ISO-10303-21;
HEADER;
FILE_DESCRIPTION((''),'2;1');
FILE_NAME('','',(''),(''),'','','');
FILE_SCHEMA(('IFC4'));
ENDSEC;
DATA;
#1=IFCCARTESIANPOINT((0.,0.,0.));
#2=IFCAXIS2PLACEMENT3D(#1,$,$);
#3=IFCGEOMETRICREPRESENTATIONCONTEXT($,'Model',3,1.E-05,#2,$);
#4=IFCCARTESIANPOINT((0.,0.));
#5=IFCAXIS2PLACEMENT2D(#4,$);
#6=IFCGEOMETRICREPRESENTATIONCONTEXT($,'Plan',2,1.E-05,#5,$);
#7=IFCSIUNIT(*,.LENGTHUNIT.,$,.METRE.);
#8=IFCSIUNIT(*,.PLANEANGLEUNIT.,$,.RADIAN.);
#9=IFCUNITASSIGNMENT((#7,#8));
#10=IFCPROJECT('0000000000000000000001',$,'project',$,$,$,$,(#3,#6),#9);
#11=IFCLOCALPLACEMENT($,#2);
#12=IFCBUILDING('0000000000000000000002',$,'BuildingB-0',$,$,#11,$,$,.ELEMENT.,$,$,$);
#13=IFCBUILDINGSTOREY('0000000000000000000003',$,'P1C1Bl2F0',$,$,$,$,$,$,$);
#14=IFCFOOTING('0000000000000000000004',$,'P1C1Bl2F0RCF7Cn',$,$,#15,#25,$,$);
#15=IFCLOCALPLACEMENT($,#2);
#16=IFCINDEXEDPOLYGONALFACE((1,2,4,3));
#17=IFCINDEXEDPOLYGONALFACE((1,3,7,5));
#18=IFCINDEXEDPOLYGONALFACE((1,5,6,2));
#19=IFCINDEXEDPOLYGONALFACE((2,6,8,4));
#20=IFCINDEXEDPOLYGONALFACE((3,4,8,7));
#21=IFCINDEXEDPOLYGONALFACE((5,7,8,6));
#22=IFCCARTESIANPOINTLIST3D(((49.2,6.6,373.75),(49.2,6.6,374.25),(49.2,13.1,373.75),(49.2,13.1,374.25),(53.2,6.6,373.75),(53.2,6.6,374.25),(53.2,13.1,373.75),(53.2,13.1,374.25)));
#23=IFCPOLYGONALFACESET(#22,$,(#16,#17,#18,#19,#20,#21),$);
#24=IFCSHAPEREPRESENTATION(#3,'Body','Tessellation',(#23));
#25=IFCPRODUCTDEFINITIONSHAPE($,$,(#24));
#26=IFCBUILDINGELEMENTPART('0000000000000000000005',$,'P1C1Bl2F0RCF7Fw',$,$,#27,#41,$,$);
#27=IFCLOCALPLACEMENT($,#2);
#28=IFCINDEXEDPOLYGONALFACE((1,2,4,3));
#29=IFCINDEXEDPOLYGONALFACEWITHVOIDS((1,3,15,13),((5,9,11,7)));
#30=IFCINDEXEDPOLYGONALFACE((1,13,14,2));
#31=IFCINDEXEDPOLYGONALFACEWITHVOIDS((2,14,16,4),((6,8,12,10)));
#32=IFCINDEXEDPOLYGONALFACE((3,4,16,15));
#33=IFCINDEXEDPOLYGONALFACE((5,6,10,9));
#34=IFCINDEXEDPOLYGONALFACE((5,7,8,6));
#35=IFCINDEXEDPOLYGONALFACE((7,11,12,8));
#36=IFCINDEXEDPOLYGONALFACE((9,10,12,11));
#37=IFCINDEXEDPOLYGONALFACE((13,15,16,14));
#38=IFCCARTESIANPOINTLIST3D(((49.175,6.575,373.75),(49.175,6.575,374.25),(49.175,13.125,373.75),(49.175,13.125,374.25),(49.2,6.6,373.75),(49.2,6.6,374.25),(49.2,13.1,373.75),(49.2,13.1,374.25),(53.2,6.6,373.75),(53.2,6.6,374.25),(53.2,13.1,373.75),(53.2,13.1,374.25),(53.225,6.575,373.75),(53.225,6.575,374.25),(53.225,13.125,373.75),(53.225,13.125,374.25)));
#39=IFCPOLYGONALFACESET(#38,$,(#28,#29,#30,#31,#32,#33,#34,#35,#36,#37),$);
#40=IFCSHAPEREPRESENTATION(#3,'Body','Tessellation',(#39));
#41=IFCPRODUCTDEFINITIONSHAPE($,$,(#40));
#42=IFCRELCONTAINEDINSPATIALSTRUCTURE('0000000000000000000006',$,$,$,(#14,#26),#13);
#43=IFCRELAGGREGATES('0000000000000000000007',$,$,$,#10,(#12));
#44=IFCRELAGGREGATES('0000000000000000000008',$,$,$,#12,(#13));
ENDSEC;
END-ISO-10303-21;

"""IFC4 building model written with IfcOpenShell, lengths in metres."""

from ifc_helpers import new_model, si_unit, origin, origin_2d, place, context, project, spatial, polyline, outline, extrude, element, save


model = new_model("IFC4")

# Units and contexts
model_context = context("Model", 3, precision=1e-05, world=origin())
plan_context = context("Plan", 2, precision=1e-05, world=origin_2d())
ifc_project = project(units=[si_unit("LENGTHUNIT", "METRE"), si_unit("PLANEANGLEUNIT", "RADIAN")], contexts=[model_context, plan_context])

# Building, storey
building_placement = place(None, origin())
building = spatial("IfcBuilding", under=ifc_project, at=building_placement, Name="BuildingB-0", CompositionType="ELEMENT")
storey = spatial("IfcBuildingStorey", under=building, Name="P1C1Bl2F0")

# Footing
element("IfcFooting", 1, inside=storey, Name="P1C1Bl2F0RCF7Cn", context=model_context, shape_type="SweptSolid", body=[
    extrude(outline(polyline([(53.2, 13.1, 373.75), (49.2, 13.1, 373.75), (49.2, 6.6, 373.75), (53.2, 6.6, 373.75), (53.2, 13.1, 373.75)])), None, (0.0, 0.0, 1.0), 0.5),
])

# Building element part, opening
building_element_part = element("IfcBuildingElementPart", 2, inside=storey, Name="P1C1Bl2F0RCF7Fw", context=model_context, shape_type="SweptSolid", body=[
    extrude(outline(polyline([(53.225, 13.125, 373.75), (49.175, 13.125, 373.75), (49.175, 6.575, 373.75), (53.225, 6.575, 373.75), (53.225, 13.125, 373.75)])), None, (0.0, 0.0, 1.0), 0.5),
])
element("IfcOpeningElement", 3, inside=storey, cuts=building_element_part, context=model_context, shape_type="SweptSolid", body=[
    extrude(outline(polyline([(53.2, 13.1, 373.75), (49.2, 13.1, 373.75), (49.2, 6.6, 373.75), (53.2, 6.6, 373.75), (53.2, 13.1, 373.75)])), None, (0.0, 0.0, 1.0), 0.5),
])

save(model, "model.ifc")
